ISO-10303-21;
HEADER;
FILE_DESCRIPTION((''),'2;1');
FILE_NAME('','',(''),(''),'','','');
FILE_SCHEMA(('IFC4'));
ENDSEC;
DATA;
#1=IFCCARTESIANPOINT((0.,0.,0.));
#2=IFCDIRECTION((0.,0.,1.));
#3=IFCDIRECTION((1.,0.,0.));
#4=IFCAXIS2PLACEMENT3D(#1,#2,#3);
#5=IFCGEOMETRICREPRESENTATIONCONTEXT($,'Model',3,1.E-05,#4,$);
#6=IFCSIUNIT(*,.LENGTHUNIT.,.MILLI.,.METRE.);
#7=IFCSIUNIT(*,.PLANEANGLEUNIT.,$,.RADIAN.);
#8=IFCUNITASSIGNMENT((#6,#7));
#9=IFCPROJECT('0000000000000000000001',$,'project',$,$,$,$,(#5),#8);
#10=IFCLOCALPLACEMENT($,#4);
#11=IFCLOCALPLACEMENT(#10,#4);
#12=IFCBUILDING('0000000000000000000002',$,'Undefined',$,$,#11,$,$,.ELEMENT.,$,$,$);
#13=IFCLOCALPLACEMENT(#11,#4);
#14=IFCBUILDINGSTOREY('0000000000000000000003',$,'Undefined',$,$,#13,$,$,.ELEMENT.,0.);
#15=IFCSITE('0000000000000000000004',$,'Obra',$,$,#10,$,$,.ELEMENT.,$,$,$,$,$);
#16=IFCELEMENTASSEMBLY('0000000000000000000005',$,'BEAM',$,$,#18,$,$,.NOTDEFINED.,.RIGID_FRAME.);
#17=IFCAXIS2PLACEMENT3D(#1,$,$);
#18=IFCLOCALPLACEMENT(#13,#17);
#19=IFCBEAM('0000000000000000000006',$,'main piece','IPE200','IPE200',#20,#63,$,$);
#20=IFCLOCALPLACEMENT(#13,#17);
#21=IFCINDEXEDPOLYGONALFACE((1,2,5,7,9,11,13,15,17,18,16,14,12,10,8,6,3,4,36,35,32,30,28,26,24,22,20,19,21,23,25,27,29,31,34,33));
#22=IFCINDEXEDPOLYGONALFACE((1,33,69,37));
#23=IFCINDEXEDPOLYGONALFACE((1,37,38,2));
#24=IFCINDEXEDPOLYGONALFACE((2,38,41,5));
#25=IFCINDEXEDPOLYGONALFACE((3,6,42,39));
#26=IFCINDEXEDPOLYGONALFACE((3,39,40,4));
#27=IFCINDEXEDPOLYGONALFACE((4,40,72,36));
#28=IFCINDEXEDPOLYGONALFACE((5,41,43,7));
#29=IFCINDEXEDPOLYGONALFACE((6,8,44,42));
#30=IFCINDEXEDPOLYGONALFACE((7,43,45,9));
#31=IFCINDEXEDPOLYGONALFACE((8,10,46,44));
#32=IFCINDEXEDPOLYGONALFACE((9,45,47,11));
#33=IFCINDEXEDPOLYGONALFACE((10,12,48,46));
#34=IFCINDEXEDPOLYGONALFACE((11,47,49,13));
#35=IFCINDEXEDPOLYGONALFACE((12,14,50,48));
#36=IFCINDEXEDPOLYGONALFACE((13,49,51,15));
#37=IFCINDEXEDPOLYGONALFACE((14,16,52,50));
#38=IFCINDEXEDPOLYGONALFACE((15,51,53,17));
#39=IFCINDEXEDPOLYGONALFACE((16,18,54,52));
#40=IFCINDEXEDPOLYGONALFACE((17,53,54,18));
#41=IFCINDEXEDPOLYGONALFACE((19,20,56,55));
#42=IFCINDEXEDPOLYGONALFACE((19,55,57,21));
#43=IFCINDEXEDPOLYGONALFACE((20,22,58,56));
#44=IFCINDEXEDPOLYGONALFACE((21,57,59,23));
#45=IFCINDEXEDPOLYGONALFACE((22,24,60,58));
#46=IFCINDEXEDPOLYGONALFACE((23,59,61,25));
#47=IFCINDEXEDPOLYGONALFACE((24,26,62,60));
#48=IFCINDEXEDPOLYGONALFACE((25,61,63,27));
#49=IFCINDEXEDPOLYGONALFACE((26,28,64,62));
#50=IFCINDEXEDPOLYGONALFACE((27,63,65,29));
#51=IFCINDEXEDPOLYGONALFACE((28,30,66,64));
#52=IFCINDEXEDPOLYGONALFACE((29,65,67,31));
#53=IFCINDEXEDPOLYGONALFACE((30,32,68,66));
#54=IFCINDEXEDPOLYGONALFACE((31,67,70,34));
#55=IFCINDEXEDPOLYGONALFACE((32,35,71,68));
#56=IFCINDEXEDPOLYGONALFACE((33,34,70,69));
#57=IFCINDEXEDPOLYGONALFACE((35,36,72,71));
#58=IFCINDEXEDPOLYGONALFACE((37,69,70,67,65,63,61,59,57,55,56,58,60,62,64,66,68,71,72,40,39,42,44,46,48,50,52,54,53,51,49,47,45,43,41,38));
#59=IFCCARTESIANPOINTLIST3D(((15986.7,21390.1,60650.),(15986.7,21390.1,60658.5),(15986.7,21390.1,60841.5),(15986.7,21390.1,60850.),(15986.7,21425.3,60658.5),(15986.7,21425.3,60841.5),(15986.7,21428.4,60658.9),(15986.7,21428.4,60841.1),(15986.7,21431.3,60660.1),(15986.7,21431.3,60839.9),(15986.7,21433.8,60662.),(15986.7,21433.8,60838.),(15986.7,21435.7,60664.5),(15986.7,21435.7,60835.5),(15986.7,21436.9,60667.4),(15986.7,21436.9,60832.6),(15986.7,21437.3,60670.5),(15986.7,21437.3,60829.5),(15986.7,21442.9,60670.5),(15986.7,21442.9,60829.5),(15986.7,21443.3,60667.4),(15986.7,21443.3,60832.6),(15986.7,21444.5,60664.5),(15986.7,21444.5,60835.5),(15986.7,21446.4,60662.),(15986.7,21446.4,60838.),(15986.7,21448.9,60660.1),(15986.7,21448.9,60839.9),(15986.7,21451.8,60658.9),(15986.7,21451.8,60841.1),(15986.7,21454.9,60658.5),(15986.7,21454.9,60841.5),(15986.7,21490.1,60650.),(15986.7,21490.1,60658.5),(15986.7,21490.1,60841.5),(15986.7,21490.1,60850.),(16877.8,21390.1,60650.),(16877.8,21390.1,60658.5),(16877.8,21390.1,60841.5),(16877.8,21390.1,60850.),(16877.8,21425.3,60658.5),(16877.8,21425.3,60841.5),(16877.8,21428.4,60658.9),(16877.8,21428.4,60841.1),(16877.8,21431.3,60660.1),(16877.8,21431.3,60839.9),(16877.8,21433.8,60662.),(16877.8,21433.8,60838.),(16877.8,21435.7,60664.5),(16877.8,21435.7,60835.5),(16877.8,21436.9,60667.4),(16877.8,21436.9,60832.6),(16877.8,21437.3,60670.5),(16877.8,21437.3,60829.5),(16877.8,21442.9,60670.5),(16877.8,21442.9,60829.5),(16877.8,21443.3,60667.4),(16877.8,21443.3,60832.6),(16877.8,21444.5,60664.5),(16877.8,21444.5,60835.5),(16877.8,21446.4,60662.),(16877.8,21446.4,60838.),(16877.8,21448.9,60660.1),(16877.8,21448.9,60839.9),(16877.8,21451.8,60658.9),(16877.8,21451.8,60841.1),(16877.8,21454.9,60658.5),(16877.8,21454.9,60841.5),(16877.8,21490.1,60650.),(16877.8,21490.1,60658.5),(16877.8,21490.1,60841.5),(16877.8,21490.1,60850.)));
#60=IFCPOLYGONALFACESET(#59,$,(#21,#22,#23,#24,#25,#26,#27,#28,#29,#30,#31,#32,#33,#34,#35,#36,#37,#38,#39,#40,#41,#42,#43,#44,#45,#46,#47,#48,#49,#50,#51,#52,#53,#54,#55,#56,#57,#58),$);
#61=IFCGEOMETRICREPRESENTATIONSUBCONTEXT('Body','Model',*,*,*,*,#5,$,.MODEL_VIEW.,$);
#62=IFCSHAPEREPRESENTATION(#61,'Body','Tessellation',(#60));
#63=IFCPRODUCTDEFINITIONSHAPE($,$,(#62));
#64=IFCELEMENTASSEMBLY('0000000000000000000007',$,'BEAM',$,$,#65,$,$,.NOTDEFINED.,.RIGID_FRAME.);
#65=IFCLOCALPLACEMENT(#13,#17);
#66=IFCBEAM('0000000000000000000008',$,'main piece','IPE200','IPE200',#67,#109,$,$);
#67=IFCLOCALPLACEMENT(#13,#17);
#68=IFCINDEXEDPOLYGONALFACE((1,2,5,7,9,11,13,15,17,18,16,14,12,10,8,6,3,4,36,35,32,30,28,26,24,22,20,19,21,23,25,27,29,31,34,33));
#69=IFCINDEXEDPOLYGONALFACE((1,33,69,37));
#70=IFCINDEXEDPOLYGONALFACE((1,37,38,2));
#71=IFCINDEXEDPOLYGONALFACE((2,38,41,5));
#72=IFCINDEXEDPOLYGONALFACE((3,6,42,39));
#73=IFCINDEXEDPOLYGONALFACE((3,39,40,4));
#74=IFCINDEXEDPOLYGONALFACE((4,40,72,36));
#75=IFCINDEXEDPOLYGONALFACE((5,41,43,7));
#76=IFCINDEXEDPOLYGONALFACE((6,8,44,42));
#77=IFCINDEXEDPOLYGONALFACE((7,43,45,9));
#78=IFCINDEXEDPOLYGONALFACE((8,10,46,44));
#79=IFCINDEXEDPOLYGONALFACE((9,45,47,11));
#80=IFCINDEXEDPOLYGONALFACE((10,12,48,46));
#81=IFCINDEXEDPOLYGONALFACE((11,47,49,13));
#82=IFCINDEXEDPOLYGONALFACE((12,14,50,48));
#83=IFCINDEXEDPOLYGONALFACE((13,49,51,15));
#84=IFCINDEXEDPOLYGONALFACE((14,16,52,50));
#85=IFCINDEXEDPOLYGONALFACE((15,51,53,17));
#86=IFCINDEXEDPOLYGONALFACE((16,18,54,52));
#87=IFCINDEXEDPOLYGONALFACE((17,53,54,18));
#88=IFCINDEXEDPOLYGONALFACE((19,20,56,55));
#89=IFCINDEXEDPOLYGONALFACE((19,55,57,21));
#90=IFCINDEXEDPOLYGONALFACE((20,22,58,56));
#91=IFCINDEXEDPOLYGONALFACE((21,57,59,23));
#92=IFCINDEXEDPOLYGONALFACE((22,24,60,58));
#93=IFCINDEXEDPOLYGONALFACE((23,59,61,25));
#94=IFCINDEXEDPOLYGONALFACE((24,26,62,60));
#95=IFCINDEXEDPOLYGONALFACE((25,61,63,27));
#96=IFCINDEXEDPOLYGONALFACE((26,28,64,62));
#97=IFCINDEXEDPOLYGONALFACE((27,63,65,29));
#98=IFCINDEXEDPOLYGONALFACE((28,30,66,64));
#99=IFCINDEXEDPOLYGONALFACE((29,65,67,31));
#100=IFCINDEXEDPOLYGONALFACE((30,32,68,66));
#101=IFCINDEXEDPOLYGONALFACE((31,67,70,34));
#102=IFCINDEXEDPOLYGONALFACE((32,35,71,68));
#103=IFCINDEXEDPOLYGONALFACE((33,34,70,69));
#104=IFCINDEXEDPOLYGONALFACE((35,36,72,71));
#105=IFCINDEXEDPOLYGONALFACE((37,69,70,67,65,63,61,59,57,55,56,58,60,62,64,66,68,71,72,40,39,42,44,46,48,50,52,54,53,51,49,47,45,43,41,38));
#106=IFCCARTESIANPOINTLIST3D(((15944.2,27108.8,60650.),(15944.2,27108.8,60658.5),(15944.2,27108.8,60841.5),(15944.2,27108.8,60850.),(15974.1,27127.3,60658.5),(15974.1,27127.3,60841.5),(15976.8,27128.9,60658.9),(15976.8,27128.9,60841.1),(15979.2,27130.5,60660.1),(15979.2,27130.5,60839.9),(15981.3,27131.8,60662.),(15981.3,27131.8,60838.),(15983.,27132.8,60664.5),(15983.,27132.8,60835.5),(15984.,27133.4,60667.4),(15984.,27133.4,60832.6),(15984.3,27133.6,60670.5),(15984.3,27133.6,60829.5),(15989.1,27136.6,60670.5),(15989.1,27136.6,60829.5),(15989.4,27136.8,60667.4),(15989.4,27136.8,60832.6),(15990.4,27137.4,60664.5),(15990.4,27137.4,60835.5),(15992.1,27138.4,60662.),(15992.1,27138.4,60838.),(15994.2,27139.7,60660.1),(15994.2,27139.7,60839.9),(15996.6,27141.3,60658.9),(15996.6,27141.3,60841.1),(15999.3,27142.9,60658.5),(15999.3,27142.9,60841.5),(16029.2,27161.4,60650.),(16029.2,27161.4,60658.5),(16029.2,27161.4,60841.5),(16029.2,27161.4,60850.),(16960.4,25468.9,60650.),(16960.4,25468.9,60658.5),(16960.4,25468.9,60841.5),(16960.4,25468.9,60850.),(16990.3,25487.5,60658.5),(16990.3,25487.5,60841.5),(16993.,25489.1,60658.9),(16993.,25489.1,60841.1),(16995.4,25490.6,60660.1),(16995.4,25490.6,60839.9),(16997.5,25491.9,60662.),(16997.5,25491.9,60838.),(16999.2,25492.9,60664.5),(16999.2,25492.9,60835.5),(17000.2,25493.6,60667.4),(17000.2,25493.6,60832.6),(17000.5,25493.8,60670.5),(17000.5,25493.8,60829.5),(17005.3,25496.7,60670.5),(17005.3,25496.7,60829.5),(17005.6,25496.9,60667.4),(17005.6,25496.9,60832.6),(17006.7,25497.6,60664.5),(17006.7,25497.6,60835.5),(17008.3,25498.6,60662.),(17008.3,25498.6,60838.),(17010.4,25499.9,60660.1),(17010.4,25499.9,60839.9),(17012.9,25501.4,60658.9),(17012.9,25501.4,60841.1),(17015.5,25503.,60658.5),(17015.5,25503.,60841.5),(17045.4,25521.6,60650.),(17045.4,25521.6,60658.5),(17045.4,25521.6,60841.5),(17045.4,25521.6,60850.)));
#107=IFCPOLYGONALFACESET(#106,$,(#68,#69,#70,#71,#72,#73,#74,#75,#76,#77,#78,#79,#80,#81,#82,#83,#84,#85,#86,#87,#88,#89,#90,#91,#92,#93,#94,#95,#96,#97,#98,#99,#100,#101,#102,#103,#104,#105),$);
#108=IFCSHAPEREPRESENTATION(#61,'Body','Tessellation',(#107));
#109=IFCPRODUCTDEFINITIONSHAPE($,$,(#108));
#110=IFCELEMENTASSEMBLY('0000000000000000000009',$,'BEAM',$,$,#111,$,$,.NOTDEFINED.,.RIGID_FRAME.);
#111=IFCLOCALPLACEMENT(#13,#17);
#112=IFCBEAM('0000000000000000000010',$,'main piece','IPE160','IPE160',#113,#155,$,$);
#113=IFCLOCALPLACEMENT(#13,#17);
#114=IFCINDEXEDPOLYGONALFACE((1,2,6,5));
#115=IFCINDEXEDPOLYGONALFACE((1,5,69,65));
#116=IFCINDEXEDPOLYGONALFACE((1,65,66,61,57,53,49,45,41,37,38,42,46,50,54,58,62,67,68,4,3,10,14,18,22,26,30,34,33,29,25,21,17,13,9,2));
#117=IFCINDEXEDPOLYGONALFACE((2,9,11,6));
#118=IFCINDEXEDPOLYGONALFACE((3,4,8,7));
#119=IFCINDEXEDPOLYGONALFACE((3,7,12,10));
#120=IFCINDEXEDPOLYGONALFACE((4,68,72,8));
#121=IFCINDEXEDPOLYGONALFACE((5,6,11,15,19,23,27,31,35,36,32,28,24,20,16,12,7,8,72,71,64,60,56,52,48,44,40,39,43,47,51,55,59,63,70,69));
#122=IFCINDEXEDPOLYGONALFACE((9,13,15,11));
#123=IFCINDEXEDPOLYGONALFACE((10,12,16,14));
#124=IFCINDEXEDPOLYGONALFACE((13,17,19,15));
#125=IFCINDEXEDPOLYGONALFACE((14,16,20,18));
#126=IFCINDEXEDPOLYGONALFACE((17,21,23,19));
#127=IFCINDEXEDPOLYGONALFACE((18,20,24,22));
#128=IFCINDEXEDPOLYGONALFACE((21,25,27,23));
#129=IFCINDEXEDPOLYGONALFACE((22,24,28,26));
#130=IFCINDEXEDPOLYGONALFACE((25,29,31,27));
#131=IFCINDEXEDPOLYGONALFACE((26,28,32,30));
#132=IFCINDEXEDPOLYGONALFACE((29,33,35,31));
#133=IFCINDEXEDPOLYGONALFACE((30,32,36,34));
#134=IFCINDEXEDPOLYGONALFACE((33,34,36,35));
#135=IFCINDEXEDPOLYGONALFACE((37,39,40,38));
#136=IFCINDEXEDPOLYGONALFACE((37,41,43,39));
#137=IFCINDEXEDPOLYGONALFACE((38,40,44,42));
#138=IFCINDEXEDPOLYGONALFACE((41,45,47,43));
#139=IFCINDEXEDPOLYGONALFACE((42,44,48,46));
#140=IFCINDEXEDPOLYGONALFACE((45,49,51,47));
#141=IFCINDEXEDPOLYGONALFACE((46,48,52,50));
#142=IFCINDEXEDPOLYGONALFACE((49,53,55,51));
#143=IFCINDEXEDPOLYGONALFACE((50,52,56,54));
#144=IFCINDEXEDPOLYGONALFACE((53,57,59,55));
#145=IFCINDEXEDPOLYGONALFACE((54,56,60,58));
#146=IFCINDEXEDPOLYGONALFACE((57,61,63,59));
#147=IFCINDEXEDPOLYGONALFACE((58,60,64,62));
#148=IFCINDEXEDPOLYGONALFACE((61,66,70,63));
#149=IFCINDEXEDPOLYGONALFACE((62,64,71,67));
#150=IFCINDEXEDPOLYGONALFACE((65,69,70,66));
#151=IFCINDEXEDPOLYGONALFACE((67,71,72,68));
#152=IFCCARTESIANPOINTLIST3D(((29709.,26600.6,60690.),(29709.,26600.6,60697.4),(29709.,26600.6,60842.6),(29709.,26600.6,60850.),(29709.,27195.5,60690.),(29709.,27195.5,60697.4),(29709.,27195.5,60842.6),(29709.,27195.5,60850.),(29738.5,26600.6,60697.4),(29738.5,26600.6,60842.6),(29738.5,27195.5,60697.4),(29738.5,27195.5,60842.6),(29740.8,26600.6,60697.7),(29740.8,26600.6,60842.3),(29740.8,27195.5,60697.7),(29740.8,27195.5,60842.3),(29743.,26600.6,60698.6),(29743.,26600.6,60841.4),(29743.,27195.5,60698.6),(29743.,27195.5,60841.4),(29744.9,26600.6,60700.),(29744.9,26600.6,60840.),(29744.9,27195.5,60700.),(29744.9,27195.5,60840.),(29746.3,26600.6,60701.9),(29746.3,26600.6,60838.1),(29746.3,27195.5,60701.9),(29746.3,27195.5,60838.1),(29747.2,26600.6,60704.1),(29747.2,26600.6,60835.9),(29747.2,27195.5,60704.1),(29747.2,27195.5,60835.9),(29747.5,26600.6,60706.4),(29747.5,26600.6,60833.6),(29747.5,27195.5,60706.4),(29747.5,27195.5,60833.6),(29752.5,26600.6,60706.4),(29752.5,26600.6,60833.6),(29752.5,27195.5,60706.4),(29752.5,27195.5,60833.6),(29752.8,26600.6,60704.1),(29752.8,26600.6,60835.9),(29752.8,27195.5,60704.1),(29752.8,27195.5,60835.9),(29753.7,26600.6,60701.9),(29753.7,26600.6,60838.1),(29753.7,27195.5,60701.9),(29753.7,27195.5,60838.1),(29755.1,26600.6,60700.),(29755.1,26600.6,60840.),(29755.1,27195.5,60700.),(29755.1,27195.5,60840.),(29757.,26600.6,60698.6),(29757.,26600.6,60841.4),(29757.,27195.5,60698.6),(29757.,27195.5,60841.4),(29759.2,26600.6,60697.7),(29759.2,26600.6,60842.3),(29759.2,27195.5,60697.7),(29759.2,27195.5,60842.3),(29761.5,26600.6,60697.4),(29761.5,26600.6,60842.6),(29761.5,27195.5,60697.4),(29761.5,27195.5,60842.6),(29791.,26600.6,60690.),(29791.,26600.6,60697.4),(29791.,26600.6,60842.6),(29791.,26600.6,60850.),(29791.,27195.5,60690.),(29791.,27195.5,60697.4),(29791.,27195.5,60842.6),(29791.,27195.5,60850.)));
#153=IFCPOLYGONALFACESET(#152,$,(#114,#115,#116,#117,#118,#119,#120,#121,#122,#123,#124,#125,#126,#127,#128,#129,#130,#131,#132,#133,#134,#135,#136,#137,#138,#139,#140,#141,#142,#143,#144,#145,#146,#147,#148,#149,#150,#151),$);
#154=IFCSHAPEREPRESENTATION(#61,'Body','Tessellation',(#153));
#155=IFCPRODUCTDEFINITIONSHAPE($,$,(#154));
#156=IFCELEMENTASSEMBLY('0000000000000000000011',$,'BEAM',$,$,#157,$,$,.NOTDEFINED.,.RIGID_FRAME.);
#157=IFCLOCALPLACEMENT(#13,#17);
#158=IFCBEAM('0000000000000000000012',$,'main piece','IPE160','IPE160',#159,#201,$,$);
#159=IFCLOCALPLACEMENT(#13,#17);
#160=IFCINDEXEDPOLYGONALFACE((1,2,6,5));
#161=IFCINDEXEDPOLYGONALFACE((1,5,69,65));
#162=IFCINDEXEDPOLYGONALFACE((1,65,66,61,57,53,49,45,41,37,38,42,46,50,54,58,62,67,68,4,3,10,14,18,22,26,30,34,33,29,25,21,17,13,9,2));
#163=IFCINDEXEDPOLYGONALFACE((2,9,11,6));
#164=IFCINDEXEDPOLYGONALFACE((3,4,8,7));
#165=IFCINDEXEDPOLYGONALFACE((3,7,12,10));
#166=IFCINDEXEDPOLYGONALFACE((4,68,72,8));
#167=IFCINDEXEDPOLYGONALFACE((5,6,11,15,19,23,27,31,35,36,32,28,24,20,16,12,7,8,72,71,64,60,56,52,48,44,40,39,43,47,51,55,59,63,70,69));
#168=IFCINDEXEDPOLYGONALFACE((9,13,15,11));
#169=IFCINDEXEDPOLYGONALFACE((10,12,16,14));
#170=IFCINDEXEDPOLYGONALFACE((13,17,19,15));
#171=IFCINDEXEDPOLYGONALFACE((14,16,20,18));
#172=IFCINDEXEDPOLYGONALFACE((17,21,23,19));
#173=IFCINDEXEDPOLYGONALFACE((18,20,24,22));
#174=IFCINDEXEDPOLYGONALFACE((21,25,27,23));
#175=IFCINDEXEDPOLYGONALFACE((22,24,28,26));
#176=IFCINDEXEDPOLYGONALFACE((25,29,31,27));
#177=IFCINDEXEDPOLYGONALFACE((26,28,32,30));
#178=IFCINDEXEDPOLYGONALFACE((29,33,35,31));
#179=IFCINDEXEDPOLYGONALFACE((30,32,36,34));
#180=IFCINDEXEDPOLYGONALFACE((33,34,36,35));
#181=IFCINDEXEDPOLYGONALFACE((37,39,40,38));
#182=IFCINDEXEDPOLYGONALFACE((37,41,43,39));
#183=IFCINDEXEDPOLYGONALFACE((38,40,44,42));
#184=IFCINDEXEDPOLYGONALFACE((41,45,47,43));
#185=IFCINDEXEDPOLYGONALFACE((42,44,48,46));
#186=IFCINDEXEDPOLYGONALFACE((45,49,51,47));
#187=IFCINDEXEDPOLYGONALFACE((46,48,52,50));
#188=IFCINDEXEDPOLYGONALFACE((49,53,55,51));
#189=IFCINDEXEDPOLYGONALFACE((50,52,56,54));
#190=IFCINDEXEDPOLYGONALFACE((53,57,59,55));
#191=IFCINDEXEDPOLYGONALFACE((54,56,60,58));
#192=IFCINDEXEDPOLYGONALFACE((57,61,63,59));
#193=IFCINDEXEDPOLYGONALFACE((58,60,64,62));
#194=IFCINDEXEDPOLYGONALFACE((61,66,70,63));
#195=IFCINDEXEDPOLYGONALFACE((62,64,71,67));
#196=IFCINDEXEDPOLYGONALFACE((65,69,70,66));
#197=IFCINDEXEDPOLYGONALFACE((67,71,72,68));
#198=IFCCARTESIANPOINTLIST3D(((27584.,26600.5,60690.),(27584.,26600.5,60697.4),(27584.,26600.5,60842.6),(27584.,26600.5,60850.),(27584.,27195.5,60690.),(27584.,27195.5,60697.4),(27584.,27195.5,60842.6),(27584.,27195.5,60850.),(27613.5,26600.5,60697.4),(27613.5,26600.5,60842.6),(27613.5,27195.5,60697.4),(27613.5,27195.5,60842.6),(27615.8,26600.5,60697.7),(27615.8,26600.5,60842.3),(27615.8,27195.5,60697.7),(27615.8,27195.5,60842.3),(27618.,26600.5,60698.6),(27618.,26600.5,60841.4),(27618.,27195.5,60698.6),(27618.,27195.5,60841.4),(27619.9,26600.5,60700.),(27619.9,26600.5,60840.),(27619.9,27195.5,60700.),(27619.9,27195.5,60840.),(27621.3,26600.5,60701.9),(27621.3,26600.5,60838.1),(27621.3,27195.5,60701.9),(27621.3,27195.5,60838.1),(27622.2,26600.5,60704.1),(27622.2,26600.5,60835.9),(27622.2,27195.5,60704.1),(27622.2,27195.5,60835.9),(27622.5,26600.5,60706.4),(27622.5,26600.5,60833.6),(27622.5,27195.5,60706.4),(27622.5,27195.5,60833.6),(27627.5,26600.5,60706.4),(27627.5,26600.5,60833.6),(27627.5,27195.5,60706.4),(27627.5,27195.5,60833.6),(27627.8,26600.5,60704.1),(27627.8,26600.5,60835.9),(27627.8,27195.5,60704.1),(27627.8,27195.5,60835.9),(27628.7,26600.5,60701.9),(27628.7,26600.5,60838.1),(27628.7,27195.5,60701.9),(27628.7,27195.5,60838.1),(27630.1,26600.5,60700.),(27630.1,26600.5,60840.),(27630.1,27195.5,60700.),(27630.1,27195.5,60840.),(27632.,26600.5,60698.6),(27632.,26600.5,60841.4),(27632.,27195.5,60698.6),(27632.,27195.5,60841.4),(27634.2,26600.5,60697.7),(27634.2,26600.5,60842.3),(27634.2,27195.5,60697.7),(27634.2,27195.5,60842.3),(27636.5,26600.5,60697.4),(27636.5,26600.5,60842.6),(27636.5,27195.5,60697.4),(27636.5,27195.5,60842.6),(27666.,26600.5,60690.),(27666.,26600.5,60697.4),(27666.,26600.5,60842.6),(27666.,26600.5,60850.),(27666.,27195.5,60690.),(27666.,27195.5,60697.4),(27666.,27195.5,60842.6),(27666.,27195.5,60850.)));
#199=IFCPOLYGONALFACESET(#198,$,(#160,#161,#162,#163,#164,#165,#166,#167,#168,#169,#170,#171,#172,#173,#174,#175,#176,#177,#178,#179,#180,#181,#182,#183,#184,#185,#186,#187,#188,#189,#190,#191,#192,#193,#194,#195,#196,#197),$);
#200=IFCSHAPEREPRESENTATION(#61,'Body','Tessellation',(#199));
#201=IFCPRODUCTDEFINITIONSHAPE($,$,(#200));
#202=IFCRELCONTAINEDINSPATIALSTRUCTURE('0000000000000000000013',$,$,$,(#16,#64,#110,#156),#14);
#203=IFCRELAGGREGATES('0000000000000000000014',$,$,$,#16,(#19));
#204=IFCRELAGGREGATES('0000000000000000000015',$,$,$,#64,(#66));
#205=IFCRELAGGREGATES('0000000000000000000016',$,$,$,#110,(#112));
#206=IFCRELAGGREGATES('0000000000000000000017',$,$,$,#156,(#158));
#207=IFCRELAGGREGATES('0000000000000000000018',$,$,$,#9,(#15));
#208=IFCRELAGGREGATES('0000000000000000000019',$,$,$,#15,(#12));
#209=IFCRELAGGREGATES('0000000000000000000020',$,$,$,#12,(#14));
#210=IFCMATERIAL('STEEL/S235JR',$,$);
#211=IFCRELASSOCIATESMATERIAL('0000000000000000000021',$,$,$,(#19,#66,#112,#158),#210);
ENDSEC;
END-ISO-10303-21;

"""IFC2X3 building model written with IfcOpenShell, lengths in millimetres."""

from ifc_helpers import new_model, si_unit, frame, origin_with_axes, origin_2d_with_axis, place, context, subcontext, project, spatial, i_section, extrude, material, element, aggregate, save


model = new_model("IFC2X3")

# Units and contexts
model_context = context("Model", 3, precision=1e-05, world=origin_with_axes())
body_context = subcontext(model_context, "Body", "Model", "MODEL_VIEW")
ifc_project = project(units=[si_unit("LENGTHUNIT", "METRE", prefix="MILLI"), si_unit("PLANEANGLEUNIT", "RADIAN")], contexts=[model_context])

# Site, building, storey
site_placement = place(None, origin_with_axes())
site = spatial("IfcSite", under=ifc_project, at=site_placement, Name="Obra", CompositionType="ELEMENT")
building_placement = place(site_placement, origin_with_axes())
building = spatial("IfcBuilding", under=site, at=building_placement, Name="Undefined", CompositionType="ELEMENT")
storey_placement = place(building_placement, origin_with_axes())
storey = spatial("IfcBuildingStorey", under=building, at=storey_placement, Name="Undefined", CompositionType="ELEMENT", Elevation=0.0)

# Element assemblies, beams
ifc_material_1 = material(Name="STEEL/S235JR")
assembly_1_placement = place(storey_placement, origin_with_axes())
assembly_1 = element("IfcElementAssembly", 1, at=assembly_1_placement, inside=storey, Name="BEAM", AssemblyPlace="NOTDEFINED", PredefinedType="RIGID_FRAME")
beam_1_placement = place(assembly_1_placement, frame((16877.8, 21440.1, 60750.0), z_axis=(0.0, 0.0, 1.0), x_axis=(-1.0, -0.000037, 0.0)))
beam_1 = element("IfcBeam", 2, at=beam_1_placement, material=ifc_material_1, Name="main piece", Description="IPE200", ObjectType="IPE200", context=body_context, shape_type="SweptSolid", body=[
    extrude(i_section(OverallWidth=100.0, OverallDepth=200.0, WebThickness=5.6, FlangeThickness=8.5, FilletRadius=12.0, at=origin_2d_with_axis()), frame((891.1, 0.0, 0.0), z_axis=(-1.0, 0.0, 0.0), x_axis=(0.0, -1.0, 0.0)), (0.0, 0.0, 1.0), 891.1),
])
aggregate(assembly_1, [beam_1])
assembly_2_placement = place(storey_placement, origin_with_axes())
assembly_2 = element("IfcElementAssembly", 3, at=assembly_2_placement, inside=storey, Name="BEAM", AssemblyPlace="NOTDEFINED", PredefinedType="RIGID_FRAME")
beam_2_placement = place(assembly_2_placement, frame((17002.9, 25495.3, 60750.0), z_axis=(0.0, 0.0, 1.0), x_axis=(-0.526756, 0.850017, 0.0)))
beam_2 = element("IfcBeam", 4, at=beam_2_placement, material=ifc_material_1, Name="main piece", Description="IPE200", ObjectType="IPE200", context=body_context, shape_type="SweptSolid", body=[
    extrude(i_section(OverallWidth=100.0, OverallDepth=200.0, WebThickness=5.6, FlangeThickness=8.5, FilletRadius=12.0, at=origin_2d_with_axis()), frame((1929.2, 0.0, 0.0), z_axis=(-1.0, 0.0, 0.0), x_axis=(0.0, -1.0, 0.0)), (0.0, 0.0, 1.0), 1929.2),
])
aggregate(assembly_2, [beam_2])
assembly_3_placement = place(storey_placement, origin_with_axes())
assembly_3 = element("IfcElementAssembly", 5, at=assembly_3_placement, inside=storey, Name="BEAM", AssemblyPlace="NOTDEFINED", PredefinedType="RIGID_FRAME")
beam_3_placement = place(assembly_3_placement, frame((29750.0, 26600.6, 60770.0), z_axis=(0.0, 0.0, 1.0), x_axis=(0.0, 1.0, 0.0)))
beam_3 = element("IfcBeam", 6, at=beam_3_placement, material=ifc_material_1, Name="main piece", Description="IPE160", ObjectType="IPE160", context=body_context, shape_type="SweptSolid", body=[
    extrude(i_section(OverallWidth=82.0, OverallDepth=160.0, WebThickness=5.0, FlangeThickness=7.4, FilletRadius=9.0, at=origin_2d_with_axis()), frame((594.9, 0.0, 0.0), z_axis=(-1.0, 0.0, 0.0), x_axis=(0.0, -1.0, 0.0)), (0.0, 0.0, 1.0), 594.9),
])
aggregate(assembly_3, [beam_3])
assembly_4_placement = place(storey_placement, origin_with_axes())
assembly_4 = element("IfcElementAssembly", 7, at=assembly_4_placement, inside=storey, Name="BEAM", AssemblyPlace="NOTDEFINED", PredefinedType="RIGID_FRAME")
beam_4_placement = place(assembly_4_placement, frame((27625.0, 26600.5, 60770.0), z_axis=(0.0, 0.0, 1.0), x_axis=(0.0, 1.0, 0.0)))
beam_4 = element("IfcBeam", 8, at=beam_4_placement, material=ifc_material_1, Name="main piece", Description="IPE160", ObjectType="IPE160", context=body_context, shape_type="SweptSolid", body=[
    extrude(i_section(OverallWidth=82.0, OverallDepth=160.0, WebThickness=5.0, FlangeThickness=7.4, FilletRadius=9.0, at=origin_2d_with_axis()), frame((595.0, 0.0, 0.0), z_axis=(-1.0, 0.0, 0.0), x_axis=(0.0, -1.0, 0.0)), (0.0, 0.0, 1.0), 595.0),
])
aggregate(assembly_4, [beam_4])

save(model, "model.ifc")
